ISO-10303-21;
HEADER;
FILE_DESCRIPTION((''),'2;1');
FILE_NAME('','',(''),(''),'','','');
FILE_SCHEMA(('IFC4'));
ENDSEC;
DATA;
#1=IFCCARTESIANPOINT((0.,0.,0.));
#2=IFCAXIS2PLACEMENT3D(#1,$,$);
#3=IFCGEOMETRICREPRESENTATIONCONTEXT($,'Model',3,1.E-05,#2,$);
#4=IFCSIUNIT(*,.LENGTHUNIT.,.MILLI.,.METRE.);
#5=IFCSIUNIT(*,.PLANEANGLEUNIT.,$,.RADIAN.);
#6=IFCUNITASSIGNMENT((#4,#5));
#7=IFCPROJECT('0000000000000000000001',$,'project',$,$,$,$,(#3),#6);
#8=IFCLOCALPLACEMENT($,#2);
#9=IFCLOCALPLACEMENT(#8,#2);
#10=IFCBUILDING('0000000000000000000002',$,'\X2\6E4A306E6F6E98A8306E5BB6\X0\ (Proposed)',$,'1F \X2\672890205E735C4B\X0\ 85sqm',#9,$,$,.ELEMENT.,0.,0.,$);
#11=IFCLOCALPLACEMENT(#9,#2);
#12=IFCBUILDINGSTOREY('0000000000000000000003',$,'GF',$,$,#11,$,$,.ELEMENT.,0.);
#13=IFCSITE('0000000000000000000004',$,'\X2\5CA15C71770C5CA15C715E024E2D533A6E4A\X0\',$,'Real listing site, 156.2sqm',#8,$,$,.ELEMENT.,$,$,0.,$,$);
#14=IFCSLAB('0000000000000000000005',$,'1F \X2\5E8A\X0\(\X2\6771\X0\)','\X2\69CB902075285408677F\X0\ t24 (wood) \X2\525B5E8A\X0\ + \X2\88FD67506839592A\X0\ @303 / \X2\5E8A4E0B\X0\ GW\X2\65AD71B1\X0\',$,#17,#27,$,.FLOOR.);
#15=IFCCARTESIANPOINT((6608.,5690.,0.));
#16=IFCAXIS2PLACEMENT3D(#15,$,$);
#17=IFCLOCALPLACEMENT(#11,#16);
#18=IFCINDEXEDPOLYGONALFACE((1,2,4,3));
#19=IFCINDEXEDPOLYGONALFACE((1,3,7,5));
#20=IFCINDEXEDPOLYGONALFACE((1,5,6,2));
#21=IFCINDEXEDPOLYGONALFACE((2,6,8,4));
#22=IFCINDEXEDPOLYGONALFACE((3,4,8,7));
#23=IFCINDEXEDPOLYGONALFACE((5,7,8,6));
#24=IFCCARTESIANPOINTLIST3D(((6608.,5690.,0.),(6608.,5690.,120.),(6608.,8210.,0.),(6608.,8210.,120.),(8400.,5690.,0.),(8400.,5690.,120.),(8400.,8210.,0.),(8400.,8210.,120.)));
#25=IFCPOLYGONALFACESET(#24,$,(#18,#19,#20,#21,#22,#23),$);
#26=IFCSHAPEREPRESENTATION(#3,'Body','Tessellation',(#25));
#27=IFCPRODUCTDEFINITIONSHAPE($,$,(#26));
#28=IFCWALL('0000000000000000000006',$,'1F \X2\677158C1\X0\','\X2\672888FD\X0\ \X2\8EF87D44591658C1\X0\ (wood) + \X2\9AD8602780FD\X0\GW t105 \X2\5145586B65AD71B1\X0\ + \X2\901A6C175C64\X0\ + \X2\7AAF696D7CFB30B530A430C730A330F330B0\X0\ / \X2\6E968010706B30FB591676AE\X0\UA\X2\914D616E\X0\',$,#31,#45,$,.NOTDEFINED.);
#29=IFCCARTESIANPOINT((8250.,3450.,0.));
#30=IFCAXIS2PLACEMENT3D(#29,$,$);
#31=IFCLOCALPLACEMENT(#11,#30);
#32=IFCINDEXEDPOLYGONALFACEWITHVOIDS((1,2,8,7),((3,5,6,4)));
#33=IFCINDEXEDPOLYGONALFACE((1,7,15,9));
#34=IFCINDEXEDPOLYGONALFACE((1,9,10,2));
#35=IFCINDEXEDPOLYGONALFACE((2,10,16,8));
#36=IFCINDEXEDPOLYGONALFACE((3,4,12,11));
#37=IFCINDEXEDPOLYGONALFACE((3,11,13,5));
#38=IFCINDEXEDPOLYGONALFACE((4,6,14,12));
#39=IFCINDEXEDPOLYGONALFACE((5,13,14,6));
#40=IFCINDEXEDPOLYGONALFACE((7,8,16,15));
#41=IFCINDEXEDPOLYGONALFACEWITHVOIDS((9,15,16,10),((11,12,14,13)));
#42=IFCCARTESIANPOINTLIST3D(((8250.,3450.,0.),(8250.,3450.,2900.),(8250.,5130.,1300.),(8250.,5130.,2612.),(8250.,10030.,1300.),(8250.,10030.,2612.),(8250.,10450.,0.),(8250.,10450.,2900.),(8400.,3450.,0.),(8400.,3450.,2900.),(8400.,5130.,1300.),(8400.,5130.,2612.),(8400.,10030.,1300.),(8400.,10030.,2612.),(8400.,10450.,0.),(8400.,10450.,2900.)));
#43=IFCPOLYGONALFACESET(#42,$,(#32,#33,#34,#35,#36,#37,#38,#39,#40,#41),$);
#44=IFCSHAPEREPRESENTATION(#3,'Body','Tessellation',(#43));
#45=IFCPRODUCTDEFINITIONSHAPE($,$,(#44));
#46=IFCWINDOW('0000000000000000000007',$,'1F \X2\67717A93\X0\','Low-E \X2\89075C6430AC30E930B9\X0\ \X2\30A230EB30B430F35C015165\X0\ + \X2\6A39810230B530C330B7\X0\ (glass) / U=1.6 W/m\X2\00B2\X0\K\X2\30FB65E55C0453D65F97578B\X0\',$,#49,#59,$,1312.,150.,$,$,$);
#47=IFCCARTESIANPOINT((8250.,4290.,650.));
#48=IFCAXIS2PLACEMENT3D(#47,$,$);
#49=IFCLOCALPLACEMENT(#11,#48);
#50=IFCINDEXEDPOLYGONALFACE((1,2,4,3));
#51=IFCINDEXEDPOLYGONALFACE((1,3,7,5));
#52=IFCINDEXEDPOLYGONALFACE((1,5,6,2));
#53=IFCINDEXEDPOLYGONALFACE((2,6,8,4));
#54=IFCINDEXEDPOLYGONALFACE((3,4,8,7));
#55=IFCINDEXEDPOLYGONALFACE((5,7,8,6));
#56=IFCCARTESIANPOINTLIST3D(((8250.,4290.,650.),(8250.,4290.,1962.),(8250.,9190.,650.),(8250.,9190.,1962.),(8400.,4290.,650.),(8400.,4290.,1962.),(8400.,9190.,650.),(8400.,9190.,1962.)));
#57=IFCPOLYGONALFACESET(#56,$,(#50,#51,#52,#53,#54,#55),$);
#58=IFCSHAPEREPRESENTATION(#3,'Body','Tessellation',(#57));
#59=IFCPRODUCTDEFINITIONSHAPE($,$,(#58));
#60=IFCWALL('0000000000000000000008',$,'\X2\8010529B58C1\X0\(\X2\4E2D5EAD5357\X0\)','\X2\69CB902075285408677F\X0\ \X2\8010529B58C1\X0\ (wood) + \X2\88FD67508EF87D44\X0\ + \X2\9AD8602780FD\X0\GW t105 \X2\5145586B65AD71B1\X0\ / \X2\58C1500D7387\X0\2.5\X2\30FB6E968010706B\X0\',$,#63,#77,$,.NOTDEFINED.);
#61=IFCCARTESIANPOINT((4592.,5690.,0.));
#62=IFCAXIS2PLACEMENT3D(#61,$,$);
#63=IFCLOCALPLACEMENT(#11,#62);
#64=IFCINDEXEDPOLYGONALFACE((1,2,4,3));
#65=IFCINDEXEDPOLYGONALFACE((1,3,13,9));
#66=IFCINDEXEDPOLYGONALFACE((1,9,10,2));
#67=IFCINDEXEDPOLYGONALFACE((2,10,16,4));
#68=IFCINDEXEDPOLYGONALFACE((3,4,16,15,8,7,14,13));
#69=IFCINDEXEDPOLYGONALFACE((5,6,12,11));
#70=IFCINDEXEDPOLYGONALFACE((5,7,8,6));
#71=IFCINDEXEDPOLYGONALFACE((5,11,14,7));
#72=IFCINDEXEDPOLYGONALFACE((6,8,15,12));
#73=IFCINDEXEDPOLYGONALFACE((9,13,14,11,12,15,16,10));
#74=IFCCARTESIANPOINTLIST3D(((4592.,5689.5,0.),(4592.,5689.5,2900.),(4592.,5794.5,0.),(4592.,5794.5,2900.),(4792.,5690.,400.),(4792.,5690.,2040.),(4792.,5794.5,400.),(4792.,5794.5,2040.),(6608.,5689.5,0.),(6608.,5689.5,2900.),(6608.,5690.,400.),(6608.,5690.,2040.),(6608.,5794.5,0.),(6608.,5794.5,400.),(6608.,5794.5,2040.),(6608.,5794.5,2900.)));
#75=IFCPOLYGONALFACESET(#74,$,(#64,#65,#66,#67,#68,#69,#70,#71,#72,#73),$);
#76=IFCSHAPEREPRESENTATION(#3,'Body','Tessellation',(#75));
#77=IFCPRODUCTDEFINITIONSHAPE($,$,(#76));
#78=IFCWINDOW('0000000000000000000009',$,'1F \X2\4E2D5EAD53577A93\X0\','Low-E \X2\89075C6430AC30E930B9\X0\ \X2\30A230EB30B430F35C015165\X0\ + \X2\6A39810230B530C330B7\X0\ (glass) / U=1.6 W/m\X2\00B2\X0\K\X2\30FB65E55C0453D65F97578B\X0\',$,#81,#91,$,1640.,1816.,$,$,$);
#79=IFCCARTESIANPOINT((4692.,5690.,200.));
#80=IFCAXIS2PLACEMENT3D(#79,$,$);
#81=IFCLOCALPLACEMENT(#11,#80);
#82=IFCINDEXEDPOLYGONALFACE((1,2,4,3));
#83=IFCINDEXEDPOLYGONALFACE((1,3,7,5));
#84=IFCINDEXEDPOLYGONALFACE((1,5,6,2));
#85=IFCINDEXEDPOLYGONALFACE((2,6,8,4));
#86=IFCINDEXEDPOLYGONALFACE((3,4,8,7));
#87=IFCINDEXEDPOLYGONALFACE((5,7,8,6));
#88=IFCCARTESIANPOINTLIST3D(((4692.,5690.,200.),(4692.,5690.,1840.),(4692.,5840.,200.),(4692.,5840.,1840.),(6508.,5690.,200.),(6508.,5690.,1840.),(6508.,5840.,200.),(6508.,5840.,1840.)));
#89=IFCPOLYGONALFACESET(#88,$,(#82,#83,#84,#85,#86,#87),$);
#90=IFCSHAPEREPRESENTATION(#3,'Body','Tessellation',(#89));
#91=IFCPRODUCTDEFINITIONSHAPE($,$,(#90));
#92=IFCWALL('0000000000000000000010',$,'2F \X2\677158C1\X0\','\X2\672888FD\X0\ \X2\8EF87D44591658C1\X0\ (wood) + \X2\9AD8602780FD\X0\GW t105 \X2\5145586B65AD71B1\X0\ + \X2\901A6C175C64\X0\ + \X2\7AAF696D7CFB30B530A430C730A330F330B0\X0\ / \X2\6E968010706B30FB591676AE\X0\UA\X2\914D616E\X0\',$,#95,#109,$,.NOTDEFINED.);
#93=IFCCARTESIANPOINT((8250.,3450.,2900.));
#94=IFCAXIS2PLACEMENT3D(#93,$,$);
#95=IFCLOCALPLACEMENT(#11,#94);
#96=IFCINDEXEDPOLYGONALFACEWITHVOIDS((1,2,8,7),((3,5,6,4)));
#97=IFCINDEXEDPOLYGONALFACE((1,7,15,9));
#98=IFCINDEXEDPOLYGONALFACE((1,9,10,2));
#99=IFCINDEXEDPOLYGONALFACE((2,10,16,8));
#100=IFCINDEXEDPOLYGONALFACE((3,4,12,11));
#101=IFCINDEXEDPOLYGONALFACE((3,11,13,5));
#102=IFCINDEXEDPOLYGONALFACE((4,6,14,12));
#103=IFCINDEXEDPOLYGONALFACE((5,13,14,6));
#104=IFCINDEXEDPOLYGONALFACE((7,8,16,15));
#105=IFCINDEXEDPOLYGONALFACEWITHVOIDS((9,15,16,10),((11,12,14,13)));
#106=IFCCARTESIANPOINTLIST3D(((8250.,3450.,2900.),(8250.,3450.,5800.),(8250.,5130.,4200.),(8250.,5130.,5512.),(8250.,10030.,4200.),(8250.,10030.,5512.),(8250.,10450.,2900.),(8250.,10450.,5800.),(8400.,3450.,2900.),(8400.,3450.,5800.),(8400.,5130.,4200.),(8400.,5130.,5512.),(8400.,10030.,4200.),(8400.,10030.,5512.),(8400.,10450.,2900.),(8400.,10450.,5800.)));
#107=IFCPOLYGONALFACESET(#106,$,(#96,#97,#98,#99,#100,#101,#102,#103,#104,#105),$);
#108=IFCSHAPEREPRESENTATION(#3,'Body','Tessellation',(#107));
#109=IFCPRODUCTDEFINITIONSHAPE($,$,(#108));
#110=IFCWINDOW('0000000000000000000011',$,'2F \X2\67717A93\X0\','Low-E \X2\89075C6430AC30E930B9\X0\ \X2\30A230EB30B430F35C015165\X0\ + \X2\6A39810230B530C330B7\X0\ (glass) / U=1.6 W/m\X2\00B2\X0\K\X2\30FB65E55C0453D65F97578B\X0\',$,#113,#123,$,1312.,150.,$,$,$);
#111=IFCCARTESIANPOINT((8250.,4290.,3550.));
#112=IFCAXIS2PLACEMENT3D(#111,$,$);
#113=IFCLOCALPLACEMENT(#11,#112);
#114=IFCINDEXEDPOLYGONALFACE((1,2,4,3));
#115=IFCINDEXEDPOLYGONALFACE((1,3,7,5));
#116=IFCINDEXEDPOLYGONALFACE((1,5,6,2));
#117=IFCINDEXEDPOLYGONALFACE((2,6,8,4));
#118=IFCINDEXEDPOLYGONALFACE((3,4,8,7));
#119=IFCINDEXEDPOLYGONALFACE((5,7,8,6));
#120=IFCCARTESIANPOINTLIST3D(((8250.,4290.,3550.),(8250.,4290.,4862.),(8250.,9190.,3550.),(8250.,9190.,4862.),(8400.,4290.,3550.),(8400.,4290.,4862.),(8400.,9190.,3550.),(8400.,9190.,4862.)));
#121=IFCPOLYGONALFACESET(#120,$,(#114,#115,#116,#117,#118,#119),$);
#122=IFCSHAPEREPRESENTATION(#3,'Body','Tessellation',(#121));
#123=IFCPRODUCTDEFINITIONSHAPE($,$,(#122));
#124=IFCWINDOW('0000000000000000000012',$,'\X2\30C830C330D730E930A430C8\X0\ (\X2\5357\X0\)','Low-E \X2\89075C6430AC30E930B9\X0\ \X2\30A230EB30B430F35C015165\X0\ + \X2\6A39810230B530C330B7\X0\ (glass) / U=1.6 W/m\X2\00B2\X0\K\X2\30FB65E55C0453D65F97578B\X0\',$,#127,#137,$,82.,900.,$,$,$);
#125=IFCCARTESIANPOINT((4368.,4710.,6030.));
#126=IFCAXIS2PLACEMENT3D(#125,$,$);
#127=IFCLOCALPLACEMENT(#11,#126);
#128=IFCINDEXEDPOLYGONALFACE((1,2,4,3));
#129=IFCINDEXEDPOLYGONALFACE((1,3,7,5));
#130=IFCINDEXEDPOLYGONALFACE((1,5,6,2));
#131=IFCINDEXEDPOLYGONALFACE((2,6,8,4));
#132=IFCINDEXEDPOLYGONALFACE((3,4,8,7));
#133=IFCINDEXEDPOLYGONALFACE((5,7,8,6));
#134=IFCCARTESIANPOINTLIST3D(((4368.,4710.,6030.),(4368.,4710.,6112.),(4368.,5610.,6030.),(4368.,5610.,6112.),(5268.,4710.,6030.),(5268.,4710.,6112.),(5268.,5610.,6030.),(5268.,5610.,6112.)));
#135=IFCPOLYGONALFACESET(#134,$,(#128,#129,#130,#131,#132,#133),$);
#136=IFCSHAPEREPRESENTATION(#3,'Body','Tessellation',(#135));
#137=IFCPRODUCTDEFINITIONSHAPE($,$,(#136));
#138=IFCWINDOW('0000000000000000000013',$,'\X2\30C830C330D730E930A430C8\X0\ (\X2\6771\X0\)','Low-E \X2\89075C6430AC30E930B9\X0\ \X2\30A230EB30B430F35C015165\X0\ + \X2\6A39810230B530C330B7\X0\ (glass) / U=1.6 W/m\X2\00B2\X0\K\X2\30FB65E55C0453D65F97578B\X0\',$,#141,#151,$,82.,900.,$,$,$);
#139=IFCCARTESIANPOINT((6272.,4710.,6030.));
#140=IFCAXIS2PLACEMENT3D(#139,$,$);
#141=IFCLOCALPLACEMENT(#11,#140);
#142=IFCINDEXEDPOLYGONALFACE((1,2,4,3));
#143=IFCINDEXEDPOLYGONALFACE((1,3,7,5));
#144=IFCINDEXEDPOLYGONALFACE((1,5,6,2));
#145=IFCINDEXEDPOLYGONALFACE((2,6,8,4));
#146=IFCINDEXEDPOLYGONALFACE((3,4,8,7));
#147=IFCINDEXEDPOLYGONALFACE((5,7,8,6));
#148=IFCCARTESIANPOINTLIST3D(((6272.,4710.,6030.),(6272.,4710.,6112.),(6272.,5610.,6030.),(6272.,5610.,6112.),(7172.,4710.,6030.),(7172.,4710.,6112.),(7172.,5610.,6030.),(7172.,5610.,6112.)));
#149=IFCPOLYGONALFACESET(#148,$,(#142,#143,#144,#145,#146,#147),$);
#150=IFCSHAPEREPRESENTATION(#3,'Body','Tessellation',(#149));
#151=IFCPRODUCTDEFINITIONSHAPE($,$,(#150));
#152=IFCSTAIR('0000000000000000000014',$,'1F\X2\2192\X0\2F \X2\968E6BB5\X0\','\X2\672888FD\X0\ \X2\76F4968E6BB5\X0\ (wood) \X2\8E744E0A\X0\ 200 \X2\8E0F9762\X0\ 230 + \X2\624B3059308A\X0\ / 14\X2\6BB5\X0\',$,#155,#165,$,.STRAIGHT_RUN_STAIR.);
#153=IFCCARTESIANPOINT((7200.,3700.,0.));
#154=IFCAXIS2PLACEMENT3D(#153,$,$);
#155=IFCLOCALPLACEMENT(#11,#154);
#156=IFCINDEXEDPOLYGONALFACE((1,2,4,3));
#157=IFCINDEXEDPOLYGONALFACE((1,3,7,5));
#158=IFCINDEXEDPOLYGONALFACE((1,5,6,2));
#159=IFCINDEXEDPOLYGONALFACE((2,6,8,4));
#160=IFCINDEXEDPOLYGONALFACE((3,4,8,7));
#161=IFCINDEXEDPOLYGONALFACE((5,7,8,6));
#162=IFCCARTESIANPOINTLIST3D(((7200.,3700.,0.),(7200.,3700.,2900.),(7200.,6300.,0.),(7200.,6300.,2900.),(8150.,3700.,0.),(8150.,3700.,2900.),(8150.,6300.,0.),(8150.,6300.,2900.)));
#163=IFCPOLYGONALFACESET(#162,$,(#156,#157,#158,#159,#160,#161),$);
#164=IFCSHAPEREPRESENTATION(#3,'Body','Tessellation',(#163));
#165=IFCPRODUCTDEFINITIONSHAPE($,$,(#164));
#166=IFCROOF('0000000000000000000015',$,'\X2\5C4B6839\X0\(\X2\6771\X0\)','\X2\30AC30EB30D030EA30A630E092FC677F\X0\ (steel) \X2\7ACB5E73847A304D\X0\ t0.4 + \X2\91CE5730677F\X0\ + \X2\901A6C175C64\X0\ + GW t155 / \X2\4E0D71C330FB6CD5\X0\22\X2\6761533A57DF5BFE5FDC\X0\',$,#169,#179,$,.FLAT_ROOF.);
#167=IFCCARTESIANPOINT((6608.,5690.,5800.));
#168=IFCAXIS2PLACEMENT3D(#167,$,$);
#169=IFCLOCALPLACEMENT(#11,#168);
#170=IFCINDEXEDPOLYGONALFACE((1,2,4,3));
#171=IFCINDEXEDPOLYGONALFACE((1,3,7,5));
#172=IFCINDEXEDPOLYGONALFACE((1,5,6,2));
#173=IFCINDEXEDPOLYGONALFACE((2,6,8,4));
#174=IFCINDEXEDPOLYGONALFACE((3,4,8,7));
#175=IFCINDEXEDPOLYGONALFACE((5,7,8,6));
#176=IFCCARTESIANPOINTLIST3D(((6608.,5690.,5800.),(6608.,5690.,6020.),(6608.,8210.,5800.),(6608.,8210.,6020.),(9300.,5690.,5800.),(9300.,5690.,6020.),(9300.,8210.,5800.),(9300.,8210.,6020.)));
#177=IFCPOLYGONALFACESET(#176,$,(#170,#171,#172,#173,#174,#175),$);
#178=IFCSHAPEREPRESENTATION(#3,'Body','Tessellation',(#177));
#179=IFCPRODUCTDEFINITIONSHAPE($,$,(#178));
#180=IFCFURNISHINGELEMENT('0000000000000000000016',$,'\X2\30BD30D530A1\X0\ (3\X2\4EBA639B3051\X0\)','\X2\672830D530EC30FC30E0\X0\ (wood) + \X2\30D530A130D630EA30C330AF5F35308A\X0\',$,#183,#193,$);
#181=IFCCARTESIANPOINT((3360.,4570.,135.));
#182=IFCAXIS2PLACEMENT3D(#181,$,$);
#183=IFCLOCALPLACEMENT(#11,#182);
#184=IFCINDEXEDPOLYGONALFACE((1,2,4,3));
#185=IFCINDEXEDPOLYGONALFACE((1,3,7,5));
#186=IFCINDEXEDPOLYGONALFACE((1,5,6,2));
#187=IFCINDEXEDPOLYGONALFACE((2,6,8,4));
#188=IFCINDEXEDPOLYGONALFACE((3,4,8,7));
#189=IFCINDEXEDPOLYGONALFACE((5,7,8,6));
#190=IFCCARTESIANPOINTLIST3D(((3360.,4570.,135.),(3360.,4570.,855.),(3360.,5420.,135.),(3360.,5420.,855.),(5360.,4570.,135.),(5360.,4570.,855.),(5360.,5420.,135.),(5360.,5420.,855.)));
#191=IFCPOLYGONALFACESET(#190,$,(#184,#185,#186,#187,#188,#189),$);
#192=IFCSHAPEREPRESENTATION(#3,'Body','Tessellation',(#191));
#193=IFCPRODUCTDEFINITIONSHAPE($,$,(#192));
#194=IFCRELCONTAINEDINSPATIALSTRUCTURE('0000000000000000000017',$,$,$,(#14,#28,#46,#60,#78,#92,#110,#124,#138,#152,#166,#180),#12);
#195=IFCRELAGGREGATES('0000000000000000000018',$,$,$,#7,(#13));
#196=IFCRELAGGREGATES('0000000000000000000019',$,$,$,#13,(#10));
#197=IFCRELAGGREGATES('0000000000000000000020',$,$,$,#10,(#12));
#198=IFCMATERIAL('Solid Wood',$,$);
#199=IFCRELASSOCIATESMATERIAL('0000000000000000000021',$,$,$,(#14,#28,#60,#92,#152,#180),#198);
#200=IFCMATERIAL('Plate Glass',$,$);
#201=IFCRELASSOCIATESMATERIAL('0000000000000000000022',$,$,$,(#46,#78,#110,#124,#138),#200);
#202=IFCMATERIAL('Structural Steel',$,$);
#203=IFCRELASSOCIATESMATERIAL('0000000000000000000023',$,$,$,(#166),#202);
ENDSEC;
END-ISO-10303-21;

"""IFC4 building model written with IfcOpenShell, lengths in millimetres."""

from ifc_helpers import new_model, si_unit, frame, frame_2d, origin, place, context, project, spatial, rectangle, extrude, material, element, fill, save


model = new_model("IFC4")

# Units and contexts
model_context = context("Model", 3, precision=1e-05, world=origin())
ifc_project = project(units=[si_unit("LENGTHUNIT", "METRE", prefix="MILLI"), si_unit("PLANEANGLEUNIT", "RADIAN")], contexts=[model_context])

# Site, building, storey
site_placement = place(None, origin())
site = spatial("IfcSite", under=ifc_project, at=site_placement, Name="岡山県岡山市中区湊", ObjectType="Real listing site, 156.2sqm", CompositionType="ELEMENT", RefElevation=0.0)
building_placement = place(site_placement, origin())
building = spatial("IfcBuilding", under=site, at=building_placement, Name="湊の潮風の家 (Proposed)", ObjectType="1F 木造平屋 85sqm", CompositionType="ELEMENT", ElevationOfRefHeight=0.0, ElevationOfTerrain=0.0)
storey_placement = place(building_placement, origin())
storey = spatial("IfcBuildingStorey", under=building, at=storey_placement, Name="GF", CompositionType="ELEMENT", Elevation=0.0)

# Slab
ifc_material_1 = material(Name="Solid Wood")
slab_placement = place(storey_placement, frame((6608.0, 5690.0, 0.0)))
element("IfcSlab", 1, at=slab_placement, inside=storey, material=ifc_material_1, Name="1F 床(東)", Description="構造用合板 t24 (wood) 剛床 + 製材根太 @303 / 床下 GW断熱", PredefinedType="FLOOR", context=model_context, shape_type="SweptSolid", body=[
    extrude(rectangle(XDim=1792.0, YDim=2520.0, at=frame_2d((896.0, 1260.0))), frame((6608.0, 5690.0, 0.0)), (0.0, 0.0, 1.0), 120.0),
])

# Walls, openings, windows
wall_1_placement = place(storey_placement, frame((8250.0, 3450.0, 0.0)))
wall_1 = element("IfcWall", 2, at=wall_1_placement, inside=storey, material=ifc_material_1, Name="1F 東壁", Description="木製 軸組外壁 (wood) + 高性能GW t105 充填断熱 + 通気層 + 窯業系サイディング / 準耐火・外皮UA配慮", PredefinedType="NOTDEFINED", context=model_context, shape_type="SweptSolid", body=[
    extrude(rectangle(XDim=150.0, YDim=7000.0, at=frame_2d((75.0, 3500.0))), frame((8250.0, 3450.0, 0.0)), (0.0, 0.0, 1.0), 2900.0),
])
opening_1_placement = place(storey_placement, frame((8250.0, 4290.0, 650.0)))
opening_1 = element("IfcOpeningElement", 3, at=opening_1_placement, cuts=wall_1, PredefinedType="NOTDEFINED", context=model_context, shape_type="SweptSolid", body=[
    extrude(rectangle(XDim=150.0, YDim=4900.0, at=frame_2d((75.0, 2450.0))), frame((8250.0, 4290.0, 650.0)), (0.0, 0.0, 1.0), 1312.0),
])
ifc_material_2 = material(Name="Plate Glass")
window_1_placement = place(storey_placement, frame((8250.0, 4290.0, 650.0)))
window_1 = element("IfcWindow", 4, at=window_1_placement, inside=storey, material=ifc_material_2, Name="1F 東窓", Description="Low-E 複層ガラス アルゴン封入 + 樹脂サッシ (glass) / U=1.6 W/m²K・日射取得型", OverallHeight=1312.0, OverallWidth=150.0, context=model_context, shape_type="SweptSolid", body=[
    extrude(rectangle(XDim=150.0, YDim=4900.0, at=frame_2d((75.0, 2450.0))), frame((8250.0, 4290.0, 650.0)), (0.0, 0.0, 1.0), 1312.0),
])
fill(opening_1, window_1)
wall_2_placement = place(storey_placement, frame((4592.0, 5690.0, 0.0)))
wall_2 = element("IfcWall", 5, at=wall_2_placement, inside=storey, material=ifc_material_1, Name="耐力壁(中庭南)", Description="構造用合板 耐力壁 (wood) + 製材軸組 + 高性能GW t105 充填断熱 / 壁倍率2.5・準耐火", PredefinedType="NOTDEFINED", context=model_context, shape_type="SweptSolid", body=[
    extrude(rectangle(XDim=2016.0, YDim=105.0, at=frame_2d((1008.0, 52.0))), frame((4592.0, 5690.0, 0.0)), (0.0, 0.0, 1.0), 2900.0),
])
opening_2_placement = place(storey_placement, frame((4692.0, 5690.0, 200.0)))
opening_2 = element("IfcOpeningElement", 6, at=opening_2_placement, cuts=wall_2, PredefinedType="NOTDEFINED", context=model_context, shape_type="SweptSolid", body=[
    extrude(rectangle(XDim=1816.0, YDim=150.0, at=frame_2d((908.0, 75.0))), frame((4692.0, 5690.0, 200.0)), (0.0, 0.0, 1.0), 1640.0),
])
window_2_placement = place(storey_placement, frame((4692.0, 5690.0, 200.0)))
window_2 = element("IfcWindow", 7, at=window_2_placement, inside=storey, material=ifc_material_2, Name="1F 中庭南窓", Description="Low-E 複層ガラス アルゴン封入 + 樹脂サッシ (glass) / U=1.6 W/m²K・日射取得型", OverallHeight=1640.0, OverallWidth=1816.0, context=model_context, shape_type="SweptSolid", body=[
    extrude(rectangle(XDim=1816.0, YDim=150.0, at=frame_2d((908.0, 75.0))), frame((4692.0, 5690.0, 200.0)), (0.0, 0.0, 1.0), 1640.0),
])
fill(opening_2, window_2)

# Wall, opening, window
wall_3_placement = place(storey_placement, frame((8250.0, 3450.0, 2900.0)))
wall_3 = element("IfcWall", 8, at=wall_3_placement, inside=storey, material=ifc_material_1, Name="2F 東壁", Description="木製 軸組外壁 (wood) + 高性能GW t105 充填断熱 + 通気層 + 窯業系サイディング / 準耐火・外皮UA配慮", PredefinedType="NOTDEFINED", context=model_context, shape_type="SweptSolid", body=[
    extrude(rectangle(XDim=150.0, YDim=7000.0, at=frame_2d((75.0, 3500.0))), frame((8250.0, 3450.0, 2900.0)), (0.0, 0.0, 1.0), 2900.0),
])
opening_3_placement = place(storey_placement, frame((8250.0, 4290.0, 3550.0)))
opening_3 = element("IfcOpeningElement", 9, at=opening_3_placement, cuts=wall_3, PredefinedType="NOTDEFINED", context=model_context, shape_type="SweptSolid", body=[
    extrude(rectangle(XDim=150.0, YDim=4900.0, at=frame_2d((75.0, 2450.0))), frame((8250.0, 4290.0, 3550.0)), (0.0, 0.0, 1.0), 1312.0),
])
window_3_placement = place(storey_placement, frame((8250.0, 4290.0, 3550.0)))
window_3 = element("IfcWindow", 10, at=window_3_placement, inside=storey, material=ifc_material_2, Name="2F 東窓", Description="Low-E 複層ガラス アルゴン封入 + 樹脂サッシ (glass) / U=1.6 W/m²K・日射取得型", OverallHeight=1312.0, OverallWidth=150.0, context=model_context, shape_type="SweptSolid", body=[
    extrude(rectangle(XDim=150.0, YDim=4900.0, at=frame_2d((75.0, 2450.0))), frame((8250.0, 4290.0, 3550.0)), (0.0, 0.0, 1.0), 1312.0),
])
fill(opening_3, window_3)

# Windows
window_4_placement = place(storey_placement, frame((4368.0, 4710.0, 6030.0)))
element("IfcWindow", 11, at=window_4_placement, inside=storey, material=ifc_material_2, Name="トップライト (南)", Description="Low-E 複層ガラス アルゴン封入 + 樹脂サッシ (glass) / U=1.6 W/m²K・日射取得型", OverallHeight=82.0, OverallWidth=900.0, context=model_context, shape_type="SweptSolid", body=[
    extrude(rectangle(XDim=900.0, YDim=900.0, at=frame_2d((450.0, 450.0))), frame((4368.0, 4710.0, 6030.0)), (0.0, 0.0, 1.0), 82.0),
])
window_5_placement = place(storey_placement, frame((6272.0, 4710.0, 6030.0)))
element("IfcWindow", 12, at=window_5_placement, inside=storey, material=ifc_material_2, Name="トップライト (東)", Description="Low-E 複層ガラス アルゴン封入 + 樹脂サッシ (glass) / U=1.6 W/m²K・日射取得型", OverallHeight=82.0, OverallWidth=900.0, context=model_context, shape_type="SweptSolid", body=[
    extrude(rectangle(XDim=900.0, YDim=900.0, at=frame_2d((450.0, 450.0))), frame((6272.0, 4710.0, 6030.0)), (0.0, 0.0, 1.0), 82.0),
])

# Stair
stair_placement = place(storey_placement, frame((7200.0, 3700.0, 0.0)))
element("IfcStair", 13, at=stair_placement, inside=storey, material=ifc_material_1, Name="1F→2F 階段", Description="木製 直階段 (wood) 蹴上 200 踏面 230 + 手すり / 14段", PredefinedType="STRAIGHT_RUN_STAIR", context=model_context, shape_type="SweptSolid", body=[
    extrude(rectangle(XDim=950.0, YDim=2600.0, at=frame_2d((475.0, 1300.0))), frame((7200.0, 3700.0, 0.0)), (0.0, 0.0, 1.0), 2900.0),
])

# Roof
ifc_material_3 = material(Name="Structural Steel")
roof_placement = place(storey_placement, frame((6608.0, 5690.0, 5800.0)))
element("IfcRoof", 14, at=roof_placement, inside=storey, material=ifc_material_3, Name="屋根(東)", Description="ガルバリウム鋼板 (steel) 立平葺き t0.4 + 野地板 + 通気層 + GW t155 / 不燃・法22条区域対応", PredefinedType="FLAT_ROOF", context=model_context, shape_type="SweptSolid", body=[
    extrude(rectangle(XDim=2692.0, YDim=2520.0, at=frame_2d((1346.0, 1260.0))), frame((6608.0, 5690.0, 5800.0)), (0.0, 0.0, 1.0), 220.0),
])

# Furnishing element
furnishing_1_placement = place(storey_placement, frame((3360.0, 4570.0, 135.0)))
element("IfcFurnishingElement", 15, at=furnishing_1_placement, inside=storey, material=ifc_material_1, Name="ソファ (3人掛け)", Description="木フレーム (wood) + ファブリック張り", context=model_context, shape_type="SweptSolid", body=[
    extrude(rectangle(XDim=2000.0, YDim=850.0, at=frame_2d((1000.0, 425.0))), frame((3360.0, 4570.0, 135.0)), (0.0, 0.0, 1.0), 720.0),
])

save(model, "model.ifc")
